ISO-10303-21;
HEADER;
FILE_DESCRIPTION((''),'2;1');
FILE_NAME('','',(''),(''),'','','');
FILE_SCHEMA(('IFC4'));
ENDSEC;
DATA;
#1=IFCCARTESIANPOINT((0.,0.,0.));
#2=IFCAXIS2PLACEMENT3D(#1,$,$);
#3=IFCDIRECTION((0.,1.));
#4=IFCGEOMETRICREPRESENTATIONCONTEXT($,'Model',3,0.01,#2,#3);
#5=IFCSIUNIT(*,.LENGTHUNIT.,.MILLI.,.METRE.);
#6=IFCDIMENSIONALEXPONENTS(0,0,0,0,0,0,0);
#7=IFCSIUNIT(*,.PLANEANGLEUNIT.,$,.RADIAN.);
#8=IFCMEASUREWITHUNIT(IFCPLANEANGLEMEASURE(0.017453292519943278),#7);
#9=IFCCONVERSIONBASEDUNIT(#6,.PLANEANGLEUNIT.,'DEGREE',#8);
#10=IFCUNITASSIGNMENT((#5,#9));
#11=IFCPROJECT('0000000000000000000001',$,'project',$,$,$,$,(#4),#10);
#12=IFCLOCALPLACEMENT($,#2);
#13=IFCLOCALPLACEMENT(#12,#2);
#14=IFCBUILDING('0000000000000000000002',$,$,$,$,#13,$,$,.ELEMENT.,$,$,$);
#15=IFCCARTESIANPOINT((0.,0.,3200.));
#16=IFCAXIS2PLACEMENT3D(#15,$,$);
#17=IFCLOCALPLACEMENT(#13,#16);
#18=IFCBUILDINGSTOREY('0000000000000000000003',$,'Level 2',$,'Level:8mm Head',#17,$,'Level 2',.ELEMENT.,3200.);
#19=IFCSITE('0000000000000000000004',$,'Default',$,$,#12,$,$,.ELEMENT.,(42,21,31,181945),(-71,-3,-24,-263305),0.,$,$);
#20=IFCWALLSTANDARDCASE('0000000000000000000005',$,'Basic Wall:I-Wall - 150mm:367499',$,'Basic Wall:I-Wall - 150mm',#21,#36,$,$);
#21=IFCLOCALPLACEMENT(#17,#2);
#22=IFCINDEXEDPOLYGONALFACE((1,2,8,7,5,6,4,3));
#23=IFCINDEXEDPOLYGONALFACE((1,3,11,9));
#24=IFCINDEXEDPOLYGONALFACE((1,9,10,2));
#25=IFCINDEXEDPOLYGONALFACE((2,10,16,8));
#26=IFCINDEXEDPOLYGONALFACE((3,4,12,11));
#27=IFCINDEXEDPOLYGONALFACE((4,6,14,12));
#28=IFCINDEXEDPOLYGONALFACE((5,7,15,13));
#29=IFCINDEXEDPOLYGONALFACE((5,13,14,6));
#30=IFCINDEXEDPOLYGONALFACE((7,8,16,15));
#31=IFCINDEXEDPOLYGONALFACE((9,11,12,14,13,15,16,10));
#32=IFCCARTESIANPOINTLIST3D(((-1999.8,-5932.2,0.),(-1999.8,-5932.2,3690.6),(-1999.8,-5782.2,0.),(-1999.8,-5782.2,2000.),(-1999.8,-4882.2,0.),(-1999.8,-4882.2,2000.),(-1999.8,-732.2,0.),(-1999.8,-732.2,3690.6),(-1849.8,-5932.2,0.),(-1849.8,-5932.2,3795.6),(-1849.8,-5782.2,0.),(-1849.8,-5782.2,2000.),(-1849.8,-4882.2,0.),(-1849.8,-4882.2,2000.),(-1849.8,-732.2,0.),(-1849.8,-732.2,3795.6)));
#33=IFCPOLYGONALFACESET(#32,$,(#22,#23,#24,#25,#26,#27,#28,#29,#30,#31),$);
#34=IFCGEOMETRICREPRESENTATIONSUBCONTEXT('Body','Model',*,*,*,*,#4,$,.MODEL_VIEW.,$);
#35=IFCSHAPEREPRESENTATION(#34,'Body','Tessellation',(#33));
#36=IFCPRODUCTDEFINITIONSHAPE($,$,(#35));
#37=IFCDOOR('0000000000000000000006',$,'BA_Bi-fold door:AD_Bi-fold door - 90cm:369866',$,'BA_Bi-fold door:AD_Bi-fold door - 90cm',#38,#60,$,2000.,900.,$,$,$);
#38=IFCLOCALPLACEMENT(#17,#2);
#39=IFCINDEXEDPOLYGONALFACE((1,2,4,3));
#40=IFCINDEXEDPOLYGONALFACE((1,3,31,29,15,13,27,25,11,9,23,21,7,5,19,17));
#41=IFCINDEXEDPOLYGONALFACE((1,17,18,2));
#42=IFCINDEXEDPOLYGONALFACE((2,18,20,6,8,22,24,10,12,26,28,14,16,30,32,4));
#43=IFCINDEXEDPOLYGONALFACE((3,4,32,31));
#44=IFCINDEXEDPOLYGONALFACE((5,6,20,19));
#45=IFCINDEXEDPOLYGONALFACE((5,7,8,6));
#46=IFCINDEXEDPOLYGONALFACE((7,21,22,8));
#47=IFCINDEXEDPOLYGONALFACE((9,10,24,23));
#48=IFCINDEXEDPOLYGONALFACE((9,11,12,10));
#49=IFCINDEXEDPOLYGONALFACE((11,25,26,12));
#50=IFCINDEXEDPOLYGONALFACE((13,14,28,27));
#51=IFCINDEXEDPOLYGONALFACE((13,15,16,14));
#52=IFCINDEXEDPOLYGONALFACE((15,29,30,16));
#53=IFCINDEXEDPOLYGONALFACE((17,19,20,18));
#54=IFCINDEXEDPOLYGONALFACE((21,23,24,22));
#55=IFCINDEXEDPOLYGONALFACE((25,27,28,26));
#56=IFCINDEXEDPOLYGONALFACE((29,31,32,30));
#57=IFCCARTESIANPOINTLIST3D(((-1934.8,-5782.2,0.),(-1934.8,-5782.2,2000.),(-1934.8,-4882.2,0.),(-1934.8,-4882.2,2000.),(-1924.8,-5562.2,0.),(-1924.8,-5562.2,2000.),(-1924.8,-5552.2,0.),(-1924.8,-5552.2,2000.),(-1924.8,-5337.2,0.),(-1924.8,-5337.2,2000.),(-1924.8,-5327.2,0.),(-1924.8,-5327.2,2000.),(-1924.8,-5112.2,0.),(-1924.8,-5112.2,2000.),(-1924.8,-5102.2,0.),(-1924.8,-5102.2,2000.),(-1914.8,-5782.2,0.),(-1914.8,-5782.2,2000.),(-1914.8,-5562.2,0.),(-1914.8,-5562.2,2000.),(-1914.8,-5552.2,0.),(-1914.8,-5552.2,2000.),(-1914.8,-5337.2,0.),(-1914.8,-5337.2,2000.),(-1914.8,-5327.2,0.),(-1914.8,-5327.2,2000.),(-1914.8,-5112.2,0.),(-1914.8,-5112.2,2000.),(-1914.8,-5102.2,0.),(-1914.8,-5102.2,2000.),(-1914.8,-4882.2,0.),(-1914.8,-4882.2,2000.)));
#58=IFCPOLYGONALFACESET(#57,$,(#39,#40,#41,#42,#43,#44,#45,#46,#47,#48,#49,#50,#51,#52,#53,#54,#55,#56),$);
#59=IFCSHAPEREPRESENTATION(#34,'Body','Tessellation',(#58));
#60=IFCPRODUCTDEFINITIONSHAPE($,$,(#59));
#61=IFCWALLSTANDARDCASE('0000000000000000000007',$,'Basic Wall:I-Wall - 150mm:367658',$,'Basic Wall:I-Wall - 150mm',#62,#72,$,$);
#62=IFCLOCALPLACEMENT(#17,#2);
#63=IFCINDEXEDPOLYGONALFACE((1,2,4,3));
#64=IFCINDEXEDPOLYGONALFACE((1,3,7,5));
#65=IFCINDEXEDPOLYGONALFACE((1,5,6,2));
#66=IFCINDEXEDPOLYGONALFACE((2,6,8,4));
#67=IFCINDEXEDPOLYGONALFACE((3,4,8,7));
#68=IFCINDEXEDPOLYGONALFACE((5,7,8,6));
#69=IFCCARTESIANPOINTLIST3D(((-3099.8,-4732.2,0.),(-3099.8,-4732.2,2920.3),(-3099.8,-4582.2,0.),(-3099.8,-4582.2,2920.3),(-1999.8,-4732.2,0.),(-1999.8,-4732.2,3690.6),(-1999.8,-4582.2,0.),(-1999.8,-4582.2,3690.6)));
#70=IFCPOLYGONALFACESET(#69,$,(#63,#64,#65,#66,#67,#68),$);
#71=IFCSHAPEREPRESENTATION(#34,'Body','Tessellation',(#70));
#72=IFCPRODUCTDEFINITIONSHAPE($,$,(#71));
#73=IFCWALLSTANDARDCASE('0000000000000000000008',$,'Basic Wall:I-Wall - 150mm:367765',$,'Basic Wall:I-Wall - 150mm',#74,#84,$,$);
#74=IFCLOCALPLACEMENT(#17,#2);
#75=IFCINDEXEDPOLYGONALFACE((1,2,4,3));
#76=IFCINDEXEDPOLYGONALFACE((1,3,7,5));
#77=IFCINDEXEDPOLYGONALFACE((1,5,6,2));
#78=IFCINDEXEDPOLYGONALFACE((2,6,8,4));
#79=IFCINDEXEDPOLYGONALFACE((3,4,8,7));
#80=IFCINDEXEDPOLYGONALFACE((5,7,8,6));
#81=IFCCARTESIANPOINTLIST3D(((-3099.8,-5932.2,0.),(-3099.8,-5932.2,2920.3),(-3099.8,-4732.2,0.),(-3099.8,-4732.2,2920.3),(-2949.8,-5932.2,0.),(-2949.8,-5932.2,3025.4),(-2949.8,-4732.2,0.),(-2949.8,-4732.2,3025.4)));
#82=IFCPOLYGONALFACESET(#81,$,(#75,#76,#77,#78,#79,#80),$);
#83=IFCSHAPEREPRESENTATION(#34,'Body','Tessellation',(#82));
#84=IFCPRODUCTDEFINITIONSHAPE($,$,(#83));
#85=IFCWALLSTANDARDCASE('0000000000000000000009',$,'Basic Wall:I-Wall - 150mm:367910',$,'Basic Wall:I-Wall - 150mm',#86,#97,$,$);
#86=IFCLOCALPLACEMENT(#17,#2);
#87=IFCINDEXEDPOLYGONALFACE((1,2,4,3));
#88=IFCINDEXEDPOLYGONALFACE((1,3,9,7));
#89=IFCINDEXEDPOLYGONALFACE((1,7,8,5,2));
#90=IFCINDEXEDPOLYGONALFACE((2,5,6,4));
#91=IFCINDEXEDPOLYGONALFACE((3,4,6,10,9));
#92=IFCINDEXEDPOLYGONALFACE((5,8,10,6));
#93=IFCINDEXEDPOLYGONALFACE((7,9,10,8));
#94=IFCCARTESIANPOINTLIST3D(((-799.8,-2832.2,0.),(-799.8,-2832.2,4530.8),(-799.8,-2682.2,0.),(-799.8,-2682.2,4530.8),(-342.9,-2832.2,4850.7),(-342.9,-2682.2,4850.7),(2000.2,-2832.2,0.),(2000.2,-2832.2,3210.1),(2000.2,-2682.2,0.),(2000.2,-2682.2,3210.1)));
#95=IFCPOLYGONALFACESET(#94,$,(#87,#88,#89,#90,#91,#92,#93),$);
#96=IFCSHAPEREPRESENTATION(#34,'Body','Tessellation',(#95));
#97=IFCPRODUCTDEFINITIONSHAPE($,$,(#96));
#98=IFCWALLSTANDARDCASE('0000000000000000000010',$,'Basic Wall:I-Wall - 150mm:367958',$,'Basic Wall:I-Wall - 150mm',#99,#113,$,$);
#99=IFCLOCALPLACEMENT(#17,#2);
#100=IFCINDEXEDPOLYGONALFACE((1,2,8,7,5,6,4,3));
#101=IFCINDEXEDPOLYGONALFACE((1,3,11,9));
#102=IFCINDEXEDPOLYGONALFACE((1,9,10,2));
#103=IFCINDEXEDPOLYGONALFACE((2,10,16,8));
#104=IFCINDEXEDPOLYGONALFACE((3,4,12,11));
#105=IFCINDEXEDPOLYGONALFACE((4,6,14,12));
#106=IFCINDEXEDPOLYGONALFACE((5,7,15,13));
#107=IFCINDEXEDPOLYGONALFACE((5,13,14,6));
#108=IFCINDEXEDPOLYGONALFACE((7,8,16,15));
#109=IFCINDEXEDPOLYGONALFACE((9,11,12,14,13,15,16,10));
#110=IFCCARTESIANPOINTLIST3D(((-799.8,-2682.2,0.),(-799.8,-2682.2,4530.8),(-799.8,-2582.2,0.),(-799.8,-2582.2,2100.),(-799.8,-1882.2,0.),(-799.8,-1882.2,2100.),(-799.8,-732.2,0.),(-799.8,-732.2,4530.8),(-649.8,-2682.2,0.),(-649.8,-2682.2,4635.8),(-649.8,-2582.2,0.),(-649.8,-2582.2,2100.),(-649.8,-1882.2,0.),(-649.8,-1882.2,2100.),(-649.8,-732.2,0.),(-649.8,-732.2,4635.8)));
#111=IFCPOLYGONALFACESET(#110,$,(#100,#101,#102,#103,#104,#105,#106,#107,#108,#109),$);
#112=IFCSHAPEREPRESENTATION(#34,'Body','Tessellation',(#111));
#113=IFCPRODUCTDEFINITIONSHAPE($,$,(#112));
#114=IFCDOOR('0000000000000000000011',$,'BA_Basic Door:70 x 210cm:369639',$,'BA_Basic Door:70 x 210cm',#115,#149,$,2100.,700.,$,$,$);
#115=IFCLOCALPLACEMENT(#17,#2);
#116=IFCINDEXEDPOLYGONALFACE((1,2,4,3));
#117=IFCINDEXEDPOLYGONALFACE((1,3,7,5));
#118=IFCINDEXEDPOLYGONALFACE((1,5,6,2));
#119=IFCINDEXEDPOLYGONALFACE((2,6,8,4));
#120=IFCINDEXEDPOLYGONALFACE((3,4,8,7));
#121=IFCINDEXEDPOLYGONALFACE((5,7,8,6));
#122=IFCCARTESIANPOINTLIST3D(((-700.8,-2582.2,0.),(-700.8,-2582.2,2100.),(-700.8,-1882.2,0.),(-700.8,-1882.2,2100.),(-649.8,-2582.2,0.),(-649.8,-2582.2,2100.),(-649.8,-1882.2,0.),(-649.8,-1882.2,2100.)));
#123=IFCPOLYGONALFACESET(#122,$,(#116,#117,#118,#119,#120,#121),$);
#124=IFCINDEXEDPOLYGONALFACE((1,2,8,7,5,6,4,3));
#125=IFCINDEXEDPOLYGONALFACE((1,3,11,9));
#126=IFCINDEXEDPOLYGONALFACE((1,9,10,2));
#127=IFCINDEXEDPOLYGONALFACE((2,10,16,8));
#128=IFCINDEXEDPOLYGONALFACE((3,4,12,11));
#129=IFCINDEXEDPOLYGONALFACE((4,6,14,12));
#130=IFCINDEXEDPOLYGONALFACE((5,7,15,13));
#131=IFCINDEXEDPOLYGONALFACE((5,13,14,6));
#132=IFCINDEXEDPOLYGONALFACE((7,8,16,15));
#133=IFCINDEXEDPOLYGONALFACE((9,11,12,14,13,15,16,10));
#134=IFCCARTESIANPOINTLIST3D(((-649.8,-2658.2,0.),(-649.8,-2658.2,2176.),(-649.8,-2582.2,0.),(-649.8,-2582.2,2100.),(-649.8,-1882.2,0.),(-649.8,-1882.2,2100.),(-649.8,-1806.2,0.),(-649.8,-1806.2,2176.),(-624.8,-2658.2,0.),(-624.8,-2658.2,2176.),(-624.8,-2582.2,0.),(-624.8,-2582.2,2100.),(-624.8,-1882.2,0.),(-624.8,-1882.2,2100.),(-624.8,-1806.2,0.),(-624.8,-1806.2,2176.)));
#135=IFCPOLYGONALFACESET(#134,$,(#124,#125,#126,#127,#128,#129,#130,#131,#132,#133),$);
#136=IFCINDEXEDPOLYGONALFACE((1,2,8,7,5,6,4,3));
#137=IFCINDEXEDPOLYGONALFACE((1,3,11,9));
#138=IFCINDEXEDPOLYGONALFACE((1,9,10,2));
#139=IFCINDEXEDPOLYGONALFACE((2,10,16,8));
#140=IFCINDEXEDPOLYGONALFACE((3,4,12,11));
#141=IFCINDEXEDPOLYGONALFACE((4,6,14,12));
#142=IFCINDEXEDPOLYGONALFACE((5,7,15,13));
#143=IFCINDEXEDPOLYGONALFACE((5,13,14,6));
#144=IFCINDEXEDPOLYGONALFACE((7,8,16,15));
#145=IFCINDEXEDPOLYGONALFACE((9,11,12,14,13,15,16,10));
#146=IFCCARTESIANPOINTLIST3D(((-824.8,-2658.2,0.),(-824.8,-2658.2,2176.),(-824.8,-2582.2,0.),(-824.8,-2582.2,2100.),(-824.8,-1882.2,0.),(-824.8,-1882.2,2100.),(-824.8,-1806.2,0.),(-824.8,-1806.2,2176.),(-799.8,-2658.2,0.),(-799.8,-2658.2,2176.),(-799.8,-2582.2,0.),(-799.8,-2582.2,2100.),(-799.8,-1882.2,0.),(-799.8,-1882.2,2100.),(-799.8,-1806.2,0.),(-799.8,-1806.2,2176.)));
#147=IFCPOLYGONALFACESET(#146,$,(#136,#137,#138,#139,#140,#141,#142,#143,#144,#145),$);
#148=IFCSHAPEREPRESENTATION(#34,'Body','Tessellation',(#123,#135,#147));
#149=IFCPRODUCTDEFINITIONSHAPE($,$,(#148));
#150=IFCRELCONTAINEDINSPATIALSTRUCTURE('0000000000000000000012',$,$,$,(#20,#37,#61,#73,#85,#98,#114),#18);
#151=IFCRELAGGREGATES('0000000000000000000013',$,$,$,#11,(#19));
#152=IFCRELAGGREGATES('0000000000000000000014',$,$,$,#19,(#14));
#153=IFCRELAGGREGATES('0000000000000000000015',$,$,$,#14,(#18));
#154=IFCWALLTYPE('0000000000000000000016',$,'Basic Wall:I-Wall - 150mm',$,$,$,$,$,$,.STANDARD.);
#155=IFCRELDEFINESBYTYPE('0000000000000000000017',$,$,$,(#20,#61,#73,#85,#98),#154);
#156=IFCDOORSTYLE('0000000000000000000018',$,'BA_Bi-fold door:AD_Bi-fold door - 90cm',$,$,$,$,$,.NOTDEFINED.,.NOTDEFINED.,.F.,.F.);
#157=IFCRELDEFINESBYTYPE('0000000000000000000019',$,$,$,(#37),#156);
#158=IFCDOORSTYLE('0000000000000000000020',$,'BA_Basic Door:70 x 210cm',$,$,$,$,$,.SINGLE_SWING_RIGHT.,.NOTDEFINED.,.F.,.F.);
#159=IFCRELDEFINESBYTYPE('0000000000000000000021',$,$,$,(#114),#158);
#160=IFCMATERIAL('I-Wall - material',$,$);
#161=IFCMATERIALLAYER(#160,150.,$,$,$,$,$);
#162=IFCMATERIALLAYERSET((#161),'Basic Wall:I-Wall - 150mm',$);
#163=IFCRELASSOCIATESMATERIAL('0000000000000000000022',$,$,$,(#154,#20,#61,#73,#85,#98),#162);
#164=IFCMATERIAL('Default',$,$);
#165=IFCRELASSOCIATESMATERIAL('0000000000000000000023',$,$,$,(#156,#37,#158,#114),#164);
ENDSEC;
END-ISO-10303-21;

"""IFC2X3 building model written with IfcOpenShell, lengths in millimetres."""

from ifc_helpers import new_model, entity, si_unit, converted_unit, direction, frame, frame_2d, origin, place, context, subcontext, project, spatial, polyline, rectangle, outline, extrude, clip, bounded_halfspace, source, transform, mapped, material, layer, layer_set, layer_usage, type_object, type_shapes, element, fill, save


model = new_model("IFC2X3")

# Units and contexts
model_context = context("Model", 3, precision=0.01, world=origin(), true_north=direction((0.0, 1.0)))
body_context = subcontext(model_context, "Body", "Model", "MODEL_VIEW")
ifc_project = project(units=[si_unit("LENGTHUNIT", "METRE", prefix="MILLI"), converted_unit("PLANEANGLEUNIT", "DEGREE", entity("IfcPlaneAngleMeasure", 0.017453292519943278), si_unit("PLANEANGLEUNIT", "RADIAN"), dimensions=[0, 0, 0, 0, 0, 0, 0])], contexts=[model_context])

# Site, building, storey
site_placement = place(None, origin())
site = spatial("IfcSite", under=ifc_project, at=site_placement, Name="Default", CompositionType="ELEMENT", RefLatitude=(42, 21, 31, 181945), RefLongitude=(-71, -3, -24, -263305), RefElevation=0.0)
building_placement = place(site_placement, origin())
building = spatial("IfcBuilding", under=site, at=building_placement, CompositionType="ELEMENT")
storey_placement = place(building_placement, frame((0.0, 0.0, 3200.0)))
storey = spatial("IfcBuildingStorey", under=building, at=storey_placement, Name="Level 2", ObjectType="Level:8mm Head", LongName="Level 2", CompositionType="ELEMENT", Elevation=3200.0)

# Shared definitions
ifc_material_1 = material(Name="Default")

# Wall, opening, door
ifc_material_2 = material(Name="I-Wall - material")
ifc_layer_1 = layer(ifc_material_2, 150.0)
ifc_layer_set_1 = layer_set([ifc_layer_1], Name="Basic Wall:I-Wall - 150mm")
wall_type_1 = type_object("IfcWallType", Name="Basic Wall:I-Wall - 150mm", PredefinedType="STANDARD", material=ifc_layer_set_1)
ifc_layer_usage_1 = layer_usage(ifc_layer_set_1, "AXIS2", "NEGATIVE", 75.0)
wall_1_placement = place(storey_placement, frame((-1924.8, -5932.2, 0.0), z_axis=(0.0, 0.0, 1.0), x_axis=(0.0, 1.0, 0.0)))
wall_1 = element("IfcWallStandardCase", 1, at=wall_1_placement, inside=storey, type_object=wall_type_1, material=ifc_layer_usage_1, Name="Basic Wall:I-Wall - 150mm:367499", ObjectType="Basic Wall:I-Wall - 150mm", context=body_context, shape_type="Clipping", body=[
    clip(extrude(rectangle(XDim=5200.0, YDim=150.0, at=frame_2d((2600.0, 0.0), x_axis=(1.0, 0.0))), origin(), (0.0, 0.0, 1.0), 3795.6), bounded_halfspace(frame((0.0, -75.0, 3795.6), z_axis=(0.0, 0.573576, 0.819152), x_axis=(-1.0, 0.0, 0.0)), False, frame((0.0, -75.0, 3795.6)), polyline([(0.0, 0.0), (5200.0, 0.0), (5200.0, 150.0), (1350.0, 150.0), (1200.0, 150.0), (0.0, 150.0), (0.0, 0.0)]))),
])
opening_1_placement = place(wall_1_placement, frame((1050.0, 75.0, 0.0)))
opening_1 = element("IfcOpeningElement", 2, at=opening_1_placement, cuts=wall_1, ObjectType="Opening", context=body_context, shape_type="SweptSolid", body=[
    extrude(rectangle(XDim=2000.0, YDim=900.0, at=frame_2d((1000.0, 450.0), x_axis=(1.0, 0.0))), frame((0.0, 0.0, 0.0), z_axis=(0.0, -1.0, 0.0), x_axis=(0.0, 0.0, 1.0)), (0.0, 0.0, 1.0), 150.0),
])
door_style_1 = type_object("IfcDoorStyle", Name="BA_Bi-fold door:AD_Bi-fold door - 90cm", ConstructionType="NOTDEFINED", OperationType="NOTDEFINED", ParameterTakesPrecedence=False, Sizeable=False, material=ifc_material_1)
shared_shape_1 = source(origin(), body_context, "Body", "SweptSolid", [
    extrude(outline(polyline([(-6.2, -230.0), (-6.2, -450.0), (13.8, -450.0), (13.8, 450.0), (-6.2, 450.0), (-6.2, 230.0), (3.8, 230.0), (3.8, 220.0), (-6.2, 220.0), (-6.2, 5.0), (3.8, 5.0), (3.8, -5.0), (-6.2, -5.0), (-6.2, -220.0), (3.8, -220.0), (3.8, -230.0), (-6.2, -230.0)])), frame((450.0, 78.7, 0.0), z_axis=(0.0, 0.0, -1.0), x_axis=(0.0, -1.0, 0.0)), (0.0, 0.0, -1.0), 2000.0),
])
type_shapes(door_style_1, [shared_shape_1])
door_1_placement = place(opening_1_placement, frame((0.0, 0.0, 0.0), z_axis=(0.0, 0.0, 1.0), x_axis=(-1.0, 0.0, 0.0)))
door_1 = element("IfcDoor", 3, at=door_1_placement, inside=storey, type_object=door_style_1, material=ifc_material_1, Name="BA_Bi-fold door:AD_Bi-fold door - 90cm:369866", ObjectType="BA_Bi-fold door:AD_Bi-fold door - 90cm", OverallHeight=2000.0, OverallWidth=900.0, context=body_context, shape_type="MappedRepresentation", body=[
    mapped(shared_shape_1, transform((0.0, 0.0, 0.0), scale=1.0)),
])
fill(opening_1, door_1)

# Walls
ifc_layer_usage_2 = layer_usage(ifc_layer_set_1, "AXIS2", "NEGATIVE", 75.0)
wall_2_placement = place(storey_placement, frame((-3099.8, -4657.2, 0.0)))
element("IfcWallStandardCase", 4, at=wall_2_placement, inside=storey, type_object=wall_type_1, material=ifc_layer_usage_2, Name="Basic Wall:I-Wall - 150mm:367658", ObjectType="Basic Wall:I-Wall - 150mm", context=body_context, shape_type="Clipping", body=[
    clip(extrude(rectangle(XDim=1100.0, YDim=150.0, at=frame_2d((550.0, 0.0), x_axis=(-1.0, 0.0))), origin(), (0.0, 0.0, 1.0), 3690.6), bounded_halfspace(frame((0.0, -75.0, 2920.3), z_axis=(-0.573576, 0.0, 0.819152), x_axis=(0.0, -1.0, 0.0)), False, frame((0.0, -75.0, 2920.3)), polyline([(0.0, 0.0), (150.0, 0.0), (1100.0, 0.0), (1100.0, 150.0), (0.0, 150.0), (0.0, 0.0)]))),
])
ifc_layer_usage_3 = layer_usage(ifc_layer_set_1, "AXIS2", "NEGATIVE", 75.0)
wall_3_placement = place(storey_placement, frame((-3024.8, -5932.2, 0.0), z_axis=(0.0, 0.0, 1.0), x_axis=(0.0, 1.0, 0.0)))
element("IfcWallStandardCase", 5, at=wall_3_placement, inside=storey, type_object=wall_type_1, material=ifc_layer_usage_3, Name="Basic Wall:I-Wall - 150mm:367765", ObjectType="Basic Wall:I-Wall - 150mm", context=body_context, shape_type="Clipping", body=[
    clip(extrude(rectangle(XDim=1200.0, YDim=150.0, at=frame_2d((600.0, 0.0), x_axis=(-1.0, 0.0))), origin(), (0.0, 0.0, 1.0), 3025.4), bounded_halfspace(frame((0.0, -75.0, 3025.4), z_axis=(0.0, 0.573576, 0.819152), x_axis=(-1.0, 0.0, 0.0)), False, frame((0.0, -75.0, 3025.4)), polyline([(0.0, 0.0), (1200.0, 0.0), (1200.0, 150.0), (0.0, 150.0), (0.0, 0.0)]))),
])
ifc_layer_usage_4 = layer_usage(ifc_layer_set_1, "AXIS2", "NEGATIVE", 75.0)
wall_4_placement = place(storey_placement, frame((2000.2, -2757.2, 0.0), z_axis=(0.0, 0.0, 1.0), x_axis=(-1.0, 0.0, 0.0)))
element("IfcWallStandardCase", 6, at=wall_4_placement, inside=storey, type_object=wall_type_1, material=ifc_layer_usage_4, Name="Basic Wall:I-Wall - 150mm:367910", ObjectType="Basic Wall:I-Wall - 150mm", context=body_context, shape_type="Clipping", body=[
    clip(clip(extrude(rectangle(XDim=2800.0, YDim=150.0, at=frame_2d((1400.0, 0.0), x_axis=(-1.0, 0.0))), origin(), (0.0, 0.0, 1.0), 4850.7), bounded_halfspace(frame((2343.1, -75.0, 4850.7), z_axis=(0.573576, 0.0, 0.819152), x_axis=(0.0, 1.0, 0.0)), False, frame((2343.1, -75.0, 4850.7)), polyline([(0.0, 0.0), (306.9, 0.0), (456.9, 0.0), (456.9, 150.0), (0.0, 150.0), (0.0, 0.0)]))), bounded_halfspace(frame((0.0, -75.0, 3210.1), z_axis=(-0.573576, 0.0, 0.819152), x_axis=(0.0, -1.0, 0.0)), False, frame((0.0, -75.0, 3210.1)), polyline([(0.0, 0.0), (2343.1, 0.0), (2343.1, 150.0), (0.0, 150.0), (0.0, 0.0)]))),
])

# Wall, opening, door
ifc_layer_usage_5 = layer_usage(ifc_layer_set_1, "AXIS2", "NEGATIVE", 75.0)
wall_5_placement = place(storey_placement, frame((-724.8, -2682.2, 0.0), z_axis=(0.0, 0.0, 1.0), x_axis=(0.0, 1.0, 0.0)))
wall_5 = element("IfcWallStandardCase", 7, at=wall_5_placement, inside=storey, type_object=wall_type_1, material=ifc_layer_usage_5, Name="Basic Wall:I-Wall - 150mm:367958", ObjectType="Basic Wall:I-Wall - 150mm", context=body_context, shape_type="Clipping", body=[
    clip(extrude(rectangle(XDim=1950.0, YDim=150.0, at=frame_2d((975.0, 0.0), x_axis=(1.0, 0.0))), origin(), (0.0, 0.0, 1.0), 4635.8), bounded_halfspace(frame((0.0, -75.0, 4635.8), z_axis=(0.0, 0.573576, 0.819152), x_axis=(-1.0, 0.0, 0.0)), False, frame((0.0, -75.0, 4635.8)), polyline([(0.0, 0.0), (1950.0, 0.0), (1950.0, 150.0), (0.0, 150.0), (0.0, 0.0)]))),
])
opening_2_placement = place(wall_5_placement, frame((800.0, 75.0, 0.0)))
opening_2 = element("IfcOpeningElement", 8, at=opening_2_placement, cuts=wall_5, ObjectType="Opening", context=body_context, shape_type="SweptSolid", body=[
    extrude(rectangle(XDim=700.0, YDim=2100.0, at=frame_2d((1050.0, 350.0), x_axis=(0.0, 1.0))), frame((0.0, 0.0, 0.0), z_axis=(0.0, -1.0, 0.0), x_axis=(0.0, 0.0, 1.0)), (0.0, 0.0, 1.0), 150.0),
])
door_style_2 = type_object("IfcDoorStyle", Name="BA_Basic Door:70 x 210cm", ConstructionType="NOTDEFINED", OperationType="SINGLE_SWING_RIGHT", ParameterTakesPrecedence=False, Sizeable=False, material=ifc_material_1)
shared_shape_2 = source(origin(), body_context, "Body", "SweptSolid", [
    extrude(rectangle(XDim=51.0, YDim=700.0, at=frame_2d((0.0, 0.0), x_axis=(1.0, 0.0))), frame((350.0, 124.5, 0.0), z_axis=(0.0, 0.0, 1.0), x_axis=(0.0, 1.0, 0.0)), (0.0, 0.0, 1.0), 2100.0),
    extrude(outline(polyline([(-426.0, -1107.0), (426.0, -1107.0), (426.0, 1069.0), (350.0, 1069.0), (350.0, -1031.0), (-350.0, -1031.0), (-350.0, 1069.0), (-426.0, 1069.0), (-426.0, -1107.0)])), frame((350.0, 150.0, 1069.0), z_axis=(0.0, 1.0, 0.0), x_axis=(1.0, 0.0, 0.0)), (0.0, 0.0, 1.0), 25.0),
    extrude(outline(polyline([(-1107.0, -426.0), (1069.0, -426.0), (1069.0, -350.0), (-1031.0, -350.0), (-1031.0, 350.0), (1069.0, 350.0), (1069.0, 426.0), (-1107.0, 426.0), (-1107.0, -426.0)])), frame((350.0, -25.0, 1069.0), z_axis=(0.0, 1.0, 0.0), x_axis=(0.0, 0.0, -1.0)), (0.0, 0.0, 1.0), 25.0),
])
type_shapes(door_style_2, [shared_shape_2])
door_2_placement = place(opening_2_placement, frame((0.0, 0.0, 0.0), z_axis=(0.0, 0.0, 1.0), x_axis=(-1.0, 0.0, 0.0)))
door_2 = element("IfcDoor", 9, at=door_2_placement, inside=storey, type_object=door_style_2, material=ifc_material_1, Name="BA_Basic Door:70 x 210cm:369639", ObjectType="BA_Basic Door:70 x 210cm", OverallHeight=2100.0, OverallWidth=700.0, context=body_context, shape_type="MappedRepresentation", body=[
    mapped(shared_shape_2, transform((0.0, 0.0, 0.0), scale=1.0)),
])
fill(opening_2, door_2)

save(model, "model.ifc")
